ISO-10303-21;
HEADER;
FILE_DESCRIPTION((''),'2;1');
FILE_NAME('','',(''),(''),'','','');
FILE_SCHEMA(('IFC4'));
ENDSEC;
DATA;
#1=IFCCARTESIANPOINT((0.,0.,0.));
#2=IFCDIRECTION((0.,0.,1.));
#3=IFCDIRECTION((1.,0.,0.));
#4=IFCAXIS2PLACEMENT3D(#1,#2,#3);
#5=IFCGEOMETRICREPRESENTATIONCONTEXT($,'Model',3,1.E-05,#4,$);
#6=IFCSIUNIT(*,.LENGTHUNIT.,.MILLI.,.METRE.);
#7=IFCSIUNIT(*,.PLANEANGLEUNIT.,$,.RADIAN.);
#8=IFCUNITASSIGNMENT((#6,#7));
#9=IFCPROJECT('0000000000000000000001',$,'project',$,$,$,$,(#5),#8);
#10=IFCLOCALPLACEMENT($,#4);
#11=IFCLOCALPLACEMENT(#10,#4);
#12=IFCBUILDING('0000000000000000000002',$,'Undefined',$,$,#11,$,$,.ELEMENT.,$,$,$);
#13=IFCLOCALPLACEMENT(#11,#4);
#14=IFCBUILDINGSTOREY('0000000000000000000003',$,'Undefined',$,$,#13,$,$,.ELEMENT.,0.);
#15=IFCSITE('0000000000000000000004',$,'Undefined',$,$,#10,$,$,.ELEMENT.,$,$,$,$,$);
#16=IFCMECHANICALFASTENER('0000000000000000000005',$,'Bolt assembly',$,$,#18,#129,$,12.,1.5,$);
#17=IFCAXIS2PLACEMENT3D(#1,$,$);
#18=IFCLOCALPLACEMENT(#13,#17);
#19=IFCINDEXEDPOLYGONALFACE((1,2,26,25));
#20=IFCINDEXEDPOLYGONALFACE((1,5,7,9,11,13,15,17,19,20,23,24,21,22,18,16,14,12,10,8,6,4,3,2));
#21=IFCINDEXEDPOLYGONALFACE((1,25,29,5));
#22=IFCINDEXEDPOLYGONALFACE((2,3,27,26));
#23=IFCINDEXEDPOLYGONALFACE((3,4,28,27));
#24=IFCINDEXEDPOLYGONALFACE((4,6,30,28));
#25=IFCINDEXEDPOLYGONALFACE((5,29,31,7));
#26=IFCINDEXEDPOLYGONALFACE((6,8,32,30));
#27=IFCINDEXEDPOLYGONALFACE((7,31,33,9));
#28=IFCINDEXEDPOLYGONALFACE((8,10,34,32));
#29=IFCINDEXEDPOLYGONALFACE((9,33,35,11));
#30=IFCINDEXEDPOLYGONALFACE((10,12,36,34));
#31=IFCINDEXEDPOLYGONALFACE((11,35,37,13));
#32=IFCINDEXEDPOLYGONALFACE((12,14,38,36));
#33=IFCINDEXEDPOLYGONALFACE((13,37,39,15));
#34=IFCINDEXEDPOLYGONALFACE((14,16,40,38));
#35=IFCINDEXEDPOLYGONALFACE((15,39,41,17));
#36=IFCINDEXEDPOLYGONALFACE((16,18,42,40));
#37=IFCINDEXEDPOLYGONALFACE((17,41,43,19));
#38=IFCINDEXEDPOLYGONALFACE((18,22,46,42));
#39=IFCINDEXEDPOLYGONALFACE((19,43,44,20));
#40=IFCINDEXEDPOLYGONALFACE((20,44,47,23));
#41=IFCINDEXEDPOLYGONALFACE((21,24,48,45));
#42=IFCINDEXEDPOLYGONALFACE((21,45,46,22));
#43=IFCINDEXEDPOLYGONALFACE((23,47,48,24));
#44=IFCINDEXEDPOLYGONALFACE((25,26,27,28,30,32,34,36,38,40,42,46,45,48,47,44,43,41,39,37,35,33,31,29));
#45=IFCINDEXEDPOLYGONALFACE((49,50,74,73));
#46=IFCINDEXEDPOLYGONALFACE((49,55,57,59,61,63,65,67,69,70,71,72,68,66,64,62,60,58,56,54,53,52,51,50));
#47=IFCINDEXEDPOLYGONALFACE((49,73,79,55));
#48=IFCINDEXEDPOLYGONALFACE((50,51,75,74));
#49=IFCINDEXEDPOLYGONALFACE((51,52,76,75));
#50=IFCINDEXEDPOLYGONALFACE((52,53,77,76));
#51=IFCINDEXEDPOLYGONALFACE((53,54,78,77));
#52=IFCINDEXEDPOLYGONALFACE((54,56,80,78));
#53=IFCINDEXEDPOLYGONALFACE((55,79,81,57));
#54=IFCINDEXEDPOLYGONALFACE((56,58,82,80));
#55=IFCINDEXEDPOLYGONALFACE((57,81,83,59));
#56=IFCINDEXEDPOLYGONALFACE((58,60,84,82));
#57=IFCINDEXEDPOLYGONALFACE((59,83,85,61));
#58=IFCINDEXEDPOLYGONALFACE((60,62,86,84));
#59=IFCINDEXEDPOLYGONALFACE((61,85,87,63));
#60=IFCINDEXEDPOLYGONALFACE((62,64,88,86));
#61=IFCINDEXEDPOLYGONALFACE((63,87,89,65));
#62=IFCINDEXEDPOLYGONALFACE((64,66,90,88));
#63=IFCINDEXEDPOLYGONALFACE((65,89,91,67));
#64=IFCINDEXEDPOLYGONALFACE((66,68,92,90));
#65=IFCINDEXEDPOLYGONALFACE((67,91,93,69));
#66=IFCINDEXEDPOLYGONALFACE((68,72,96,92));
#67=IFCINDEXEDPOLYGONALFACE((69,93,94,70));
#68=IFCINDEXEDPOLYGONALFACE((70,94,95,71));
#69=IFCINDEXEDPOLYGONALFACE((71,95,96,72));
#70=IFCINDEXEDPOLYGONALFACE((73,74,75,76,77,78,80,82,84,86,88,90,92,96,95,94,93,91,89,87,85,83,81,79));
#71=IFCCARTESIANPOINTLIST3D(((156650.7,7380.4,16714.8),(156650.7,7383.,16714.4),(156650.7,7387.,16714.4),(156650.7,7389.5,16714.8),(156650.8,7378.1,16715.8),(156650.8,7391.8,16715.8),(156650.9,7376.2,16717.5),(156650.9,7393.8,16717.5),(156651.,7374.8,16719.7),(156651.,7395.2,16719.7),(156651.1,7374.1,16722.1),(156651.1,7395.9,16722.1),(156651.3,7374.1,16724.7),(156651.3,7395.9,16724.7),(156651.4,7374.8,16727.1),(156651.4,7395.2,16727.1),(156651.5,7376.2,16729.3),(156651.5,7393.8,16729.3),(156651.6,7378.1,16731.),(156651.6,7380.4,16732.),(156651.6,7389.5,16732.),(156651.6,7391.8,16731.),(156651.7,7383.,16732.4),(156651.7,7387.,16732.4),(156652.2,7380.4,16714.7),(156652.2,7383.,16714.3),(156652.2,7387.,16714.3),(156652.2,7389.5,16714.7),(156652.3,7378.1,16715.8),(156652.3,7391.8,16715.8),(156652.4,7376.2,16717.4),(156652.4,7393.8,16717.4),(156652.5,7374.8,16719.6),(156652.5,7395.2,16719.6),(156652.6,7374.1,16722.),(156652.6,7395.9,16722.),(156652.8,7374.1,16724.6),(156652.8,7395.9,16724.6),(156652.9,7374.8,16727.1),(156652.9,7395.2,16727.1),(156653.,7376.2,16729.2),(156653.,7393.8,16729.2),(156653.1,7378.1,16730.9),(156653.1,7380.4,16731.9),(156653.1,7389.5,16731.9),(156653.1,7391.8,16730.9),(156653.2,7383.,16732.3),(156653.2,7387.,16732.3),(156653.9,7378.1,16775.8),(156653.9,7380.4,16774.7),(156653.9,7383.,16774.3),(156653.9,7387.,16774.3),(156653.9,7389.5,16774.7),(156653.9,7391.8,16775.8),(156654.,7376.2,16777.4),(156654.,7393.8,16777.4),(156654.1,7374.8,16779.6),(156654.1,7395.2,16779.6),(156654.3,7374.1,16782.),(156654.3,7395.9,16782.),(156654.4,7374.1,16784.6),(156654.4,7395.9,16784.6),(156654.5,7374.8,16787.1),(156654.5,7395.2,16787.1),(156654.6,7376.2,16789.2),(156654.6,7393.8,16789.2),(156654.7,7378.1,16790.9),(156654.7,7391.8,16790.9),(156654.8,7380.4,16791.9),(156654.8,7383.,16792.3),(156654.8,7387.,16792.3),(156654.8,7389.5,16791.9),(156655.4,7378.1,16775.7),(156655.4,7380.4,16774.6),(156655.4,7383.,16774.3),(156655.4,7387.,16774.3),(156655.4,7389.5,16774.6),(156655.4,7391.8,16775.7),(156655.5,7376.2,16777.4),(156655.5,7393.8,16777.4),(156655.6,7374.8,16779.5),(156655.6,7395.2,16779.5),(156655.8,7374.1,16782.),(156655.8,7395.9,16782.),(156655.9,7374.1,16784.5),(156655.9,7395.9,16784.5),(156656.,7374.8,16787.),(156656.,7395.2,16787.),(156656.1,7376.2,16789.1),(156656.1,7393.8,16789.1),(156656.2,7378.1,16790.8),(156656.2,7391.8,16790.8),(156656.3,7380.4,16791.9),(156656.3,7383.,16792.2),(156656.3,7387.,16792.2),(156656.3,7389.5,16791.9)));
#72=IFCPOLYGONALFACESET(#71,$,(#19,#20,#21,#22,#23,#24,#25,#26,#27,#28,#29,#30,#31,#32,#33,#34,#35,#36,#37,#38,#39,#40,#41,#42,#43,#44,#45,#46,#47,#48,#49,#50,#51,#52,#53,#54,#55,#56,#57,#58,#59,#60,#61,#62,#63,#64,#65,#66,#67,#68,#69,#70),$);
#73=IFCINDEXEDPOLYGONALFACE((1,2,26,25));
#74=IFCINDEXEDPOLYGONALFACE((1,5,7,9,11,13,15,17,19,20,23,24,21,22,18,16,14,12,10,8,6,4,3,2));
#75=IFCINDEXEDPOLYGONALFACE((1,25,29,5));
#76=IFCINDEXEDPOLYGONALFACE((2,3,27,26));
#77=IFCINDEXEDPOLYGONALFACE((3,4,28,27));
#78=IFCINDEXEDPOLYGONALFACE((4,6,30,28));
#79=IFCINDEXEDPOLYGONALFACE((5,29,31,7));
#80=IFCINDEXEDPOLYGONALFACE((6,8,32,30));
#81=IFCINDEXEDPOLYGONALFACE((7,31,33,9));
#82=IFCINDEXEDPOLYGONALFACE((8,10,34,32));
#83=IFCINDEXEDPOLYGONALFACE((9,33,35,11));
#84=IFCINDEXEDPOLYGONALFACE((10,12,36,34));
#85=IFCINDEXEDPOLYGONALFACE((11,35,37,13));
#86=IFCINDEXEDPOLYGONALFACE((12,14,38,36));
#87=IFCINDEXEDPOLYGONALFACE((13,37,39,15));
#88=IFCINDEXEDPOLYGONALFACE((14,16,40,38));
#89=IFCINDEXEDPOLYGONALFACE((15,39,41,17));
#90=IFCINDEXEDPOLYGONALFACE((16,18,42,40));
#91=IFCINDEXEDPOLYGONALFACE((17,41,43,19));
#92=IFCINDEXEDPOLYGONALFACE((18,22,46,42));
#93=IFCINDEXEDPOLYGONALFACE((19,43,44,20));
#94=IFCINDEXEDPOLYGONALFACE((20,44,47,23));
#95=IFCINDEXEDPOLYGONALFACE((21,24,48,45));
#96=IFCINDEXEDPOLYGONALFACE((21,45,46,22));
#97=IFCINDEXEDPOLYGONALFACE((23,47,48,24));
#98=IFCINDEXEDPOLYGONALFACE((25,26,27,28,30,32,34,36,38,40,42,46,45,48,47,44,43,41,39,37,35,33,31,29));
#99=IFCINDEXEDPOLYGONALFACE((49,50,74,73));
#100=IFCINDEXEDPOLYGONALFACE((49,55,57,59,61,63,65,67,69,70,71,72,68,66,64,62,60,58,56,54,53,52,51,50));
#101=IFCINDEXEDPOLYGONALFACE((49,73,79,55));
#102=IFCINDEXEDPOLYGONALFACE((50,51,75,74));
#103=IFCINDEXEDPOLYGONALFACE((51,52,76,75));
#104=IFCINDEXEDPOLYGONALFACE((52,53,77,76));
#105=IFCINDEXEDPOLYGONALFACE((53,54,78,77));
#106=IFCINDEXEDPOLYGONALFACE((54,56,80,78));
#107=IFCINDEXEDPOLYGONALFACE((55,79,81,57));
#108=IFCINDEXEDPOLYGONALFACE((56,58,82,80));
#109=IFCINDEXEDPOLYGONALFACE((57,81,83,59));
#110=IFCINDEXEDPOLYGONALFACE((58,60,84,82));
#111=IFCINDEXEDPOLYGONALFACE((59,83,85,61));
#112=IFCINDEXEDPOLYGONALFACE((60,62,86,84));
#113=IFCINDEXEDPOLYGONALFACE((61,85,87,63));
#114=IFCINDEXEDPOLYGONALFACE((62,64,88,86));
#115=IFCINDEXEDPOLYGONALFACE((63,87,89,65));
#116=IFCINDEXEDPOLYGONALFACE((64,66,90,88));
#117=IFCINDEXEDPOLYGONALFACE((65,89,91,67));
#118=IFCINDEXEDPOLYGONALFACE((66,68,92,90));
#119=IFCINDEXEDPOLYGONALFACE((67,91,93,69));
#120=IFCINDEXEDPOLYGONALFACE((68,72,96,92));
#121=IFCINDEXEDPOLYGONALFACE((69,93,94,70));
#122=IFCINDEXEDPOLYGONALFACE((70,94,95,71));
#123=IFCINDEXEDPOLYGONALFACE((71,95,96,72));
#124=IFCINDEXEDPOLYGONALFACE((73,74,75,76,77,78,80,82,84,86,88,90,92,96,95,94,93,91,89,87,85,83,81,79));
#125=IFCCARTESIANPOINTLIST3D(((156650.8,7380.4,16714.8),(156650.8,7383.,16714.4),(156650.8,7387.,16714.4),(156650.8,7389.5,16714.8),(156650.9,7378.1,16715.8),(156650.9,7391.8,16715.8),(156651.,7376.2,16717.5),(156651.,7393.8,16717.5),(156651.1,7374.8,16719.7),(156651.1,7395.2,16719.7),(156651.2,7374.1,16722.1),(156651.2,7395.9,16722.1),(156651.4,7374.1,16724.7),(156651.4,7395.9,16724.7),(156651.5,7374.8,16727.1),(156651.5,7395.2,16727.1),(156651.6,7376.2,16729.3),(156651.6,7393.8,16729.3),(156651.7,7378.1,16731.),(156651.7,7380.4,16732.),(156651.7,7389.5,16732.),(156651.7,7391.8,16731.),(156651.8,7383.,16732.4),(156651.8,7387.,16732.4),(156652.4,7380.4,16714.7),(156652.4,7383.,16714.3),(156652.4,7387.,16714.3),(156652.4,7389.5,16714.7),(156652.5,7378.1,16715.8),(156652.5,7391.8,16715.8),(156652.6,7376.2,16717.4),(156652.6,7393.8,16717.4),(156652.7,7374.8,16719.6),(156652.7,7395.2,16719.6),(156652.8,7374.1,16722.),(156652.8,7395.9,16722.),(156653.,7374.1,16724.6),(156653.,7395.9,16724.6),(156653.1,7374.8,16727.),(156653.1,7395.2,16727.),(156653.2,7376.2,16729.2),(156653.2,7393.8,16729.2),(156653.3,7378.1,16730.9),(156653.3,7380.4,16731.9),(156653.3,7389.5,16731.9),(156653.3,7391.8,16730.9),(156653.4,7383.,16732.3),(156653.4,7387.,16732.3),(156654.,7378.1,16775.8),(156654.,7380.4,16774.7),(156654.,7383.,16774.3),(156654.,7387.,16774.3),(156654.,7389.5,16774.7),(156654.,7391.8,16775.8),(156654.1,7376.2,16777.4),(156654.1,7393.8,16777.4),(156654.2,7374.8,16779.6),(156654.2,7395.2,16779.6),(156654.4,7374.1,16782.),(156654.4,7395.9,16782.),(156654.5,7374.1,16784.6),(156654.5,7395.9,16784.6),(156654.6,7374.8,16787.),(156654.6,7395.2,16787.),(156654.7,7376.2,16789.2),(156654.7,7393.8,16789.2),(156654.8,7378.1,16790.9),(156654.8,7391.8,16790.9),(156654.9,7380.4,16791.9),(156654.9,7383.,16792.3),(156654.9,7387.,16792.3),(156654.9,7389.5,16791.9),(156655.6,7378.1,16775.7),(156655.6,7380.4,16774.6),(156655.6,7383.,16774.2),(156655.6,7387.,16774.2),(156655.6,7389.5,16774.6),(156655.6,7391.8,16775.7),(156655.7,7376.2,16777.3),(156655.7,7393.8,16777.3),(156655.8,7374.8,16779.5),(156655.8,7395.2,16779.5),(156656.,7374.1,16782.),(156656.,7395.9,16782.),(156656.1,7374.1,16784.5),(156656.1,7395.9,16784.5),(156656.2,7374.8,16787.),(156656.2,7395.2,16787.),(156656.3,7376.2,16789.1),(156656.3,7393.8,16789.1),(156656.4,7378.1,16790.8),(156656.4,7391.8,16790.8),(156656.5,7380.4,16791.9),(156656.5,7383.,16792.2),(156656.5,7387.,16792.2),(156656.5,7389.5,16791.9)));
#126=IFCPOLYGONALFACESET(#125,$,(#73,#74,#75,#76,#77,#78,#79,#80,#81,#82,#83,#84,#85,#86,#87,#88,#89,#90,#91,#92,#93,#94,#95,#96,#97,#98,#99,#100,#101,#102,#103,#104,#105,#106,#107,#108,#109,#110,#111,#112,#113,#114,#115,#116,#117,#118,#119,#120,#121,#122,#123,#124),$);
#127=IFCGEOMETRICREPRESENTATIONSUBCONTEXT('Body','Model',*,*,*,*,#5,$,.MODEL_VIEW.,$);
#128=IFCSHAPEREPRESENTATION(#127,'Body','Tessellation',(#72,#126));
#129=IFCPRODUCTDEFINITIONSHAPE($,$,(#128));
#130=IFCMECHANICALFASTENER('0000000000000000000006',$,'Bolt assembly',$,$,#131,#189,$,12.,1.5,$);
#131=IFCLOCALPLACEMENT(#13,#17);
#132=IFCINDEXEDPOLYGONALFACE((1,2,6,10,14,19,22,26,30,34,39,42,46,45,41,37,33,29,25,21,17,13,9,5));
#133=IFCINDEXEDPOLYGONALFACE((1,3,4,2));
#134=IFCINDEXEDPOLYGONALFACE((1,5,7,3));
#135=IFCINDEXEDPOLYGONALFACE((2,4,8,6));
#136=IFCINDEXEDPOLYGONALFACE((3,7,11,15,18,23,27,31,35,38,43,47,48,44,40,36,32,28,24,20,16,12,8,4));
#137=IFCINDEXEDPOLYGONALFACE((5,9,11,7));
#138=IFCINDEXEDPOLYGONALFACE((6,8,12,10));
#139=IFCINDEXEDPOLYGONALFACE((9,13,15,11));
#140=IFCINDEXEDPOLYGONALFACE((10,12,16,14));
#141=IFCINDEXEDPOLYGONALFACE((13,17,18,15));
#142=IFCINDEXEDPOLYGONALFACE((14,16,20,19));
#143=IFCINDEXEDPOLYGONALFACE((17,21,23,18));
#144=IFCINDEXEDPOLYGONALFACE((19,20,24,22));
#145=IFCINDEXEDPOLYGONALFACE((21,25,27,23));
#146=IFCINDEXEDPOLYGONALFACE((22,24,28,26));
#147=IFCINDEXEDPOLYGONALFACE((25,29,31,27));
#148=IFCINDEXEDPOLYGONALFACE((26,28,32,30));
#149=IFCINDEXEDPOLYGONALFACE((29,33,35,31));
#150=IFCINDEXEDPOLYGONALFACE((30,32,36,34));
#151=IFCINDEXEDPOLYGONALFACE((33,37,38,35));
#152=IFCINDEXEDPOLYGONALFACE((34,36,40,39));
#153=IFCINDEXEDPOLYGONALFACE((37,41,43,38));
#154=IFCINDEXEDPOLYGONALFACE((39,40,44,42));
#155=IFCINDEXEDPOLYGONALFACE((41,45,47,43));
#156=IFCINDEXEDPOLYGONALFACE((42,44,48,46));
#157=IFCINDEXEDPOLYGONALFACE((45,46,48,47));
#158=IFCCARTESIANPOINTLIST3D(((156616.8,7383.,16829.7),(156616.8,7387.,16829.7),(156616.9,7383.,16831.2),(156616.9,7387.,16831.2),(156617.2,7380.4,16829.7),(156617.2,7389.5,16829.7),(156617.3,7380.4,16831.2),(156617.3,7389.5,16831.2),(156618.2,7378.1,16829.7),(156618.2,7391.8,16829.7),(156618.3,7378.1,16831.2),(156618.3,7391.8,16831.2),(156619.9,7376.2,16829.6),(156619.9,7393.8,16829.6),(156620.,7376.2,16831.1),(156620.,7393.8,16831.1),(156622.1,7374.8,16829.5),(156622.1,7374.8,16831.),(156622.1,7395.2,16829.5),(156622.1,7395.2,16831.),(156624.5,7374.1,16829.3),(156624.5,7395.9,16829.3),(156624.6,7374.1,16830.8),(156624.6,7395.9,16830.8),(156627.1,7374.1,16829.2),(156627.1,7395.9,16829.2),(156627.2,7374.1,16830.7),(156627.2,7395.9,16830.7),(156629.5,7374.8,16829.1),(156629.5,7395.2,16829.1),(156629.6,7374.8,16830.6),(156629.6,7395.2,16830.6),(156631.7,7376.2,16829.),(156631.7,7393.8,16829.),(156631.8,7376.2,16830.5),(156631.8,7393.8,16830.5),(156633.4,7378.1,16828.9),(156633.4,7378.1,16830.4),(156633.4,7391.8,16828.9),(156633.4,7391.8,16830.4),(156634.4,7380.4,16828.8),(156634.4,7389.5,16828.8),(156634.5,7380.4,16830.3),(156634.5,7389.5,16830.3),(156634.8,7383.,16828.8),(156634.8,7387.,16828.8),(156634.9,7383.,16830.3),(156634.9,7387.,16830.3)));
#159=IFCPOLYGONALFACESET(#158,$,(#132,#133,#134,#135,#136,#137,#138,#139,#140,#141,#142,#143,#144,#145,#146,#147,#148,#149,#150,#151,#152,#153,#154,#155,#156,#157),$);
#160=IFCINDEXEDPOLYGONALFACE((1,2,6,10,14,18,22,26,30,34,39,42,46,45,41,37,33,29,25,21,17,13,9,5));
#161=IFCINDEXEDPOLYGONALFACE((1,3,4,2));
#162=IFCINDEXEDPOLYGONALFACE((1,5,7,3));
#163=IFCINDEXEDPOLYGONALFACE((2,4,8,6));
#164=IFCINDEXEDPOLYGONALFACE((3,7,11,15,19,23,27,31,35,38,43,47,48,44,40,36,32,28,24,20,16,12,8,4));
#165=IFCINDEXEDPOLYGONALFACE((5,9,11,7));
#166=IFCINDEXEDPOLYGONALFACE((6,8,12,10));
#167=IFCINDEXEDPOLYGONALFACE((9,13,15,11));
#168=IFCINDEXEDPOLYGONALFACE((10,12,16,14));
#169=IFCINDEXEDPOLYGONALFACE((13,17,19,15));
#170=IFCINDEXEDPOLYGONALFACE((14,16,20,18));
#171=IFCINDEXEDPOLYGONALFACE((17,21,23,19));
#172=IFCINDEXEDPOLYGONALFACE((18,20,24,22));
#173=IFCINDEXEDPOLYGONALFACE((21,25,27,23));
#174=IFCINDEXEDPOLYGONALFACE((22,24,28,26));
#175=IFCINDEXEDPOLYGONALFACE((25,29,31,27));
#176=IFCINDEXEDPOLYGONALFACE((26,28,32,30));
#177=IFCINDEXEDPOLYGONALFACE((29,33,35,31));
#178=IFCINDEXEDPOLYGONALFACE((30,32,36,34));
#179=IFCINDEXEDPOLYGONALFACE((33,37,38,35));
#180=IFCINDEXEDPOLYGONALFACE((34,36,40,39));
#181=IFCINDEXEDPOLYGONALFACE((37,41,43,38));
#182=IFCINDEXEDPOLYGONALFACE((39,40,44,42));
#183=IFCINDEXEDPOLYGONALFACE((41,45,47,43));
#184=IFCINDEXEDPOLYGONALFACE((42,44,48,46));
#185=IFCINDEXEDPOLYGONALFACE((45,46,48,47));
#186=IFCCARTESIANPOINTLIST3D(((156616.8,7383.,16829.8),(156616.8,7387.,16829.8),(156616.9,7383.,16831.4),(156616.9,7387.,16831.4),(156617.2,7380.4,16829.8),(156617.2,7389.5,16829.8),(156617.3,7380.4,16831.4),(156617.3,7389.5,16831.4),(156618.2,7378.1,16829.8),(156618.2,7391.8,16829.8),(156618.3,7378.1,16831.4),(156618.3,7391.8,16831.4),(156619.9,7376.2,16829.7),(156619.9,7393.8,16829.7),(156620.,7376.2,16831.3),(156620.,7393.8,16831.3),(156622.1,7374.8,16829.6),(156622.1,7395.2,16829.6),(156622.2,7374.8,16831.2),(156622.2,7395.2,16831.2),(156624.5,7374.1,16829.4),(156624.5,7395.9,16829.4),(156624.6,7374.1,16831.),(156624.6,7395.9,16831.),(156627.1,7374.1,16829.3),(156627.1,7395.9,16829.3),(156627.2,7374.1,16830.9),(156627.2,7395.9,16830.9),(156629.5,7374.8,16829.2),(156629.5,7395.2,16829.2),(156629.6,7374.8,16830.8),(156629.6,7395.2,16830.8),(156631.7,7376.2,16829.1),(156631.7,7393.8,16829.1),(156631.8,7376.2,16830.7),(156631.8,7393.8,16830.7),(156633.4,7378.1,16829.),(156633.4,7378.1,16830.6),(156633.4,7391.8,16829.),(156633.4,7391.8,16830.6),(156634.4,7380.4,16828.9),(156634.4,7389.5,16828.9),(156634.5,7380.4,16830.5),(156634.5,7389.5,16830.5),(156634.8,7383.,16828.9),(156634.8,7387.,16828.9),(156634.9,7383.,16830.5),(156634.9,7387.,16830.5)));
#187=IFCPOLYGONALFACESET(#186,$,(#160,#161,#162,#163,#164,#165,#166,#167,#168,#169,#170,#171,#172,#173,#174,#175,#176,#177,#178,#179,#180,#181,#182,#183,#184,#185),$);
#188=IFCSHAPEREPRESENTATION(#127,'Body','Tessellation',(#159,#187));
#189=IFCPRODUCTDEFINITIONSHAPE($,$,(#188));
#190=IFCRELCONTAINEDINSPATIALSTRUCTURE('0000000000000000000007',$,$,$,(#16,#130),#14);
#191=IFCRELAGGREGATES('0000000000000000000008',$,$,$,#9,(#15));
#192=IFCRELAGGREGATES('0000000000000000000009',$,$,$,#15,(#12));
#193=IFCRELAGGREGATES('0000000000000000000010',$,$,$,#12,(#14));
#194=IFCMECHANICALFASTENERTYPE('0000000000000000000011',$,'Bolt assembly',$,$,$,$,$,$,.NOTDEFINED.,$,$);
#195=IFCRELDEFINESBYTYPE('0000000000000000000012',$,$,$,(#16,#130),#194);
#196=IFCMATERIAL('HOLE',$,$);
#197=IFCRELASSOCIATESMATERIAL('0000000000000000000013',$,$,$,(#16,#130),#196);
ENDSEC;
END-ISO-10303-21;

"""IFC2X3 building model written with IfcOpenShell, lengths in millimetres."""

from ifc_helpers import new_model, entity, si_unit, frame, origin_with_axes, place, context, subcontext, project, spatial, source, transform, mapped, material, type_object, element, save


model = new_model("IFC2X3")

# Units and contexts
model_context = context("Model", 3, precision=1e-05, world=origin_with_axes())
body_context = subcontext(model_context, "Body", "Model", "MODEL_VIEW")
ifc_project = project(units=[si_unit("LENGTHUNIT", "METRE", prefix="MILLI"), si_unit("PLANEANGLEUNIT", "RADIAN")], contexts=[model_context])

# Site, building, storey
site_placement = place(None, origin_with_axes())
site = spatial("IfcSite", under=ifc_project, at=site_placement, Name="Undefined", CompositionType="ELEMENT")
building_placement = place(site_placement, origin_with_axes())
building = spatial("IfcBuilding", under=site, at=building_placement, Name="Undefined", CompositionType="ELEMENT")
storey_placement = place(building_placement, origin_with_axes())
storey = spatial("IfcBuildingStorey", under=building, at=storey_placement, Name="Undefined", CompositionType="ELEMENT", Elevation=0.0)

# Mechanical fasteners
ifc_material_1 = material(Name="HOLE")
mechanical_fastener_type = type_object("IfcMechanicalFastenerType", Name="Bolt assembly")
shared_circle_1 = entity("IfcCircle", entity("IfcAxis2Placement2D", entity("IfcCartesianPoint", [0.0, -2.0]), entity("IfcDirection", [1.0, 0.0])), 9.0)
shared_circle_2 = entity("IfcCircle", entity("IfcAxis2Placement2D", entity("IfcCartesianPoint", [0.0, 2.0]), entity("IfcDirection", [-1.0, 0.0])), 9.0)
shared_composite_curve = entity("IfcCompositeCurve", [entity("IfcCompositeCurveSegment", "CONTINUOUS", True, entity("IfcPolyline", [entity("IfcCartesianPoint", [9.0, 2.0]), entity("IfcCartesianPoint", [9.0, -2.0])])), entity("IfcCompositeCurveSegment", "CONTINUOUS", True, entity("IfcTrimmedCurve", shared_circle_1, [entity("IfcParameterValue", 0.0)], [entity("IfcParameterValue", 3.141593)], False, "PARAMETER")), entity("IfcCompositeCurveSegment", "CONTINUOUS", True, entity("IfcPolyline", [entity("IfcCartesianPoint", [-9.0, -2.0]), entity("IfcCartesianPoint", [-9.0, 2.0])])), entity("IfcCompositeCurveSegment", "DISCONTINUOUS", True, entity("IfcTrimmedCurve", shared_circle_2, [entity("IfcParameterValue", 0.0)], [entity("IfcParameterValue", 3.141593)], False, "PARAMETER"))], False)
shared_shape_1 = source(origin_with_axes(), body_context, "Body", "SweptSolid", [
    entity("IfcExtrudedAreaSolid", entity("IfcArbitraryClosedProfileDef", "AREA", None, shared_composite_curve), entity("IfcAxis2Placement3D", entity("IfcCartesianPoint", [0.0, 0.1, 0.0]), entity("IfcDirection", [0.0, 1.0, 0.0]), entity("IfcDirection", [1.0, 0.0, 0.0])), entity("IfcDirection", [0.0, 0.0, 1.0]), 1.5),
    entity("IfcExtrudedAreaSolid", entity("IfcArbitraryClosedProfileDef", "AREA", None, shared_composite_curve), entity("IfcAxis2Placement3D", entity("IfcCartesianPoint", [0.0, -0.1, 0.0]), entity("IfcDirection", [0.0, 1.0, 0.0]), entity("IfcDirection", [1.0, 0.0, 0.0])), entity("IfcDirection", [0.0, 0.0, 1.0]), 1.6),
])
mechanical_fastener_1_placement = place(storey_placement, frame((156655.9, 7385.0, 16783.2), z_axis=(0.0, 1.0, 0.0), x_axis=(-0.052392, 0.0, -0.998627)))
element("IfcMechanicalFastener", 1, at=mechanical_fastener_1_placement, inside=storey, type_object=mechanical_fastener_type, material=ifc_material_1, Name="Bolt assembly", NominalDiameter=12.0, NominalLength=1.5, context=body_context, shape_type="MappedRepresentation", body=[
    mapped(shared_shape_1, transform((0.0, 0.0, 0.0))),
    mapped(shared_shape_1, transform((60.0, 0.0, 0.0))),
])
shared_shape_2 = source(origin_with_axes(), body_context, "Body", "SweptSolid", [
    entity("IfcExtrudedAreaSolid", entity("IfcArbitraryClosedProfileDef", "AREA", None, shared_composite_curve), entity("IfcAxis2Placement3D", entity("IfcCartesianPoint", [0.0, -0.9, 0.0]), entity("IfcDirection", [0.0, 1.0, 0.0]), entity("IfcDirection", [1.0, 0.0, 0.0])), entity("IfcDirection", [0.0, 0.0, 1.0]), 1.5),
    entity("IfcExtrudedAreaSolid", entity("IfcArbitraryClosedProfileDef", "AREA", None, shared_composite_curve), entity("IfcAxis2Placement3D", entity("IfcCartesianPoint", [0.0, -1.1, 0.0]), entity("IfcDirection", [0.0, 1.0, 0.0]), entity("IfcDirection", [1.0, 0.0, 0.0])), entity("IfcDirection", [0.0, 0.0, 1.0]), 1.6),
])
mechanical_fastener_2_placement = place(storey_placement, frame((156625.8, 7385.0, 16829.9), z_axis=(0.0, 1.0, 0.0), x_axis=(0.998627, 0.0, -0.052392)))
element("IfcMechanicalFastener", 2, at=mechanical_fastener_2_placement, inside=storey, type_object=mechanical_fastener_type, material=ifc_material_1, Name="Bolt assembly", NominalDiameter=12.0, NominalLength=1.5, context=body_context, shape_type="MappedRepresentation", body=[
    mapped(shared_shape_2, transform((0.0, 0.0, 0.0))),
])

save(model, "model.ifc")
